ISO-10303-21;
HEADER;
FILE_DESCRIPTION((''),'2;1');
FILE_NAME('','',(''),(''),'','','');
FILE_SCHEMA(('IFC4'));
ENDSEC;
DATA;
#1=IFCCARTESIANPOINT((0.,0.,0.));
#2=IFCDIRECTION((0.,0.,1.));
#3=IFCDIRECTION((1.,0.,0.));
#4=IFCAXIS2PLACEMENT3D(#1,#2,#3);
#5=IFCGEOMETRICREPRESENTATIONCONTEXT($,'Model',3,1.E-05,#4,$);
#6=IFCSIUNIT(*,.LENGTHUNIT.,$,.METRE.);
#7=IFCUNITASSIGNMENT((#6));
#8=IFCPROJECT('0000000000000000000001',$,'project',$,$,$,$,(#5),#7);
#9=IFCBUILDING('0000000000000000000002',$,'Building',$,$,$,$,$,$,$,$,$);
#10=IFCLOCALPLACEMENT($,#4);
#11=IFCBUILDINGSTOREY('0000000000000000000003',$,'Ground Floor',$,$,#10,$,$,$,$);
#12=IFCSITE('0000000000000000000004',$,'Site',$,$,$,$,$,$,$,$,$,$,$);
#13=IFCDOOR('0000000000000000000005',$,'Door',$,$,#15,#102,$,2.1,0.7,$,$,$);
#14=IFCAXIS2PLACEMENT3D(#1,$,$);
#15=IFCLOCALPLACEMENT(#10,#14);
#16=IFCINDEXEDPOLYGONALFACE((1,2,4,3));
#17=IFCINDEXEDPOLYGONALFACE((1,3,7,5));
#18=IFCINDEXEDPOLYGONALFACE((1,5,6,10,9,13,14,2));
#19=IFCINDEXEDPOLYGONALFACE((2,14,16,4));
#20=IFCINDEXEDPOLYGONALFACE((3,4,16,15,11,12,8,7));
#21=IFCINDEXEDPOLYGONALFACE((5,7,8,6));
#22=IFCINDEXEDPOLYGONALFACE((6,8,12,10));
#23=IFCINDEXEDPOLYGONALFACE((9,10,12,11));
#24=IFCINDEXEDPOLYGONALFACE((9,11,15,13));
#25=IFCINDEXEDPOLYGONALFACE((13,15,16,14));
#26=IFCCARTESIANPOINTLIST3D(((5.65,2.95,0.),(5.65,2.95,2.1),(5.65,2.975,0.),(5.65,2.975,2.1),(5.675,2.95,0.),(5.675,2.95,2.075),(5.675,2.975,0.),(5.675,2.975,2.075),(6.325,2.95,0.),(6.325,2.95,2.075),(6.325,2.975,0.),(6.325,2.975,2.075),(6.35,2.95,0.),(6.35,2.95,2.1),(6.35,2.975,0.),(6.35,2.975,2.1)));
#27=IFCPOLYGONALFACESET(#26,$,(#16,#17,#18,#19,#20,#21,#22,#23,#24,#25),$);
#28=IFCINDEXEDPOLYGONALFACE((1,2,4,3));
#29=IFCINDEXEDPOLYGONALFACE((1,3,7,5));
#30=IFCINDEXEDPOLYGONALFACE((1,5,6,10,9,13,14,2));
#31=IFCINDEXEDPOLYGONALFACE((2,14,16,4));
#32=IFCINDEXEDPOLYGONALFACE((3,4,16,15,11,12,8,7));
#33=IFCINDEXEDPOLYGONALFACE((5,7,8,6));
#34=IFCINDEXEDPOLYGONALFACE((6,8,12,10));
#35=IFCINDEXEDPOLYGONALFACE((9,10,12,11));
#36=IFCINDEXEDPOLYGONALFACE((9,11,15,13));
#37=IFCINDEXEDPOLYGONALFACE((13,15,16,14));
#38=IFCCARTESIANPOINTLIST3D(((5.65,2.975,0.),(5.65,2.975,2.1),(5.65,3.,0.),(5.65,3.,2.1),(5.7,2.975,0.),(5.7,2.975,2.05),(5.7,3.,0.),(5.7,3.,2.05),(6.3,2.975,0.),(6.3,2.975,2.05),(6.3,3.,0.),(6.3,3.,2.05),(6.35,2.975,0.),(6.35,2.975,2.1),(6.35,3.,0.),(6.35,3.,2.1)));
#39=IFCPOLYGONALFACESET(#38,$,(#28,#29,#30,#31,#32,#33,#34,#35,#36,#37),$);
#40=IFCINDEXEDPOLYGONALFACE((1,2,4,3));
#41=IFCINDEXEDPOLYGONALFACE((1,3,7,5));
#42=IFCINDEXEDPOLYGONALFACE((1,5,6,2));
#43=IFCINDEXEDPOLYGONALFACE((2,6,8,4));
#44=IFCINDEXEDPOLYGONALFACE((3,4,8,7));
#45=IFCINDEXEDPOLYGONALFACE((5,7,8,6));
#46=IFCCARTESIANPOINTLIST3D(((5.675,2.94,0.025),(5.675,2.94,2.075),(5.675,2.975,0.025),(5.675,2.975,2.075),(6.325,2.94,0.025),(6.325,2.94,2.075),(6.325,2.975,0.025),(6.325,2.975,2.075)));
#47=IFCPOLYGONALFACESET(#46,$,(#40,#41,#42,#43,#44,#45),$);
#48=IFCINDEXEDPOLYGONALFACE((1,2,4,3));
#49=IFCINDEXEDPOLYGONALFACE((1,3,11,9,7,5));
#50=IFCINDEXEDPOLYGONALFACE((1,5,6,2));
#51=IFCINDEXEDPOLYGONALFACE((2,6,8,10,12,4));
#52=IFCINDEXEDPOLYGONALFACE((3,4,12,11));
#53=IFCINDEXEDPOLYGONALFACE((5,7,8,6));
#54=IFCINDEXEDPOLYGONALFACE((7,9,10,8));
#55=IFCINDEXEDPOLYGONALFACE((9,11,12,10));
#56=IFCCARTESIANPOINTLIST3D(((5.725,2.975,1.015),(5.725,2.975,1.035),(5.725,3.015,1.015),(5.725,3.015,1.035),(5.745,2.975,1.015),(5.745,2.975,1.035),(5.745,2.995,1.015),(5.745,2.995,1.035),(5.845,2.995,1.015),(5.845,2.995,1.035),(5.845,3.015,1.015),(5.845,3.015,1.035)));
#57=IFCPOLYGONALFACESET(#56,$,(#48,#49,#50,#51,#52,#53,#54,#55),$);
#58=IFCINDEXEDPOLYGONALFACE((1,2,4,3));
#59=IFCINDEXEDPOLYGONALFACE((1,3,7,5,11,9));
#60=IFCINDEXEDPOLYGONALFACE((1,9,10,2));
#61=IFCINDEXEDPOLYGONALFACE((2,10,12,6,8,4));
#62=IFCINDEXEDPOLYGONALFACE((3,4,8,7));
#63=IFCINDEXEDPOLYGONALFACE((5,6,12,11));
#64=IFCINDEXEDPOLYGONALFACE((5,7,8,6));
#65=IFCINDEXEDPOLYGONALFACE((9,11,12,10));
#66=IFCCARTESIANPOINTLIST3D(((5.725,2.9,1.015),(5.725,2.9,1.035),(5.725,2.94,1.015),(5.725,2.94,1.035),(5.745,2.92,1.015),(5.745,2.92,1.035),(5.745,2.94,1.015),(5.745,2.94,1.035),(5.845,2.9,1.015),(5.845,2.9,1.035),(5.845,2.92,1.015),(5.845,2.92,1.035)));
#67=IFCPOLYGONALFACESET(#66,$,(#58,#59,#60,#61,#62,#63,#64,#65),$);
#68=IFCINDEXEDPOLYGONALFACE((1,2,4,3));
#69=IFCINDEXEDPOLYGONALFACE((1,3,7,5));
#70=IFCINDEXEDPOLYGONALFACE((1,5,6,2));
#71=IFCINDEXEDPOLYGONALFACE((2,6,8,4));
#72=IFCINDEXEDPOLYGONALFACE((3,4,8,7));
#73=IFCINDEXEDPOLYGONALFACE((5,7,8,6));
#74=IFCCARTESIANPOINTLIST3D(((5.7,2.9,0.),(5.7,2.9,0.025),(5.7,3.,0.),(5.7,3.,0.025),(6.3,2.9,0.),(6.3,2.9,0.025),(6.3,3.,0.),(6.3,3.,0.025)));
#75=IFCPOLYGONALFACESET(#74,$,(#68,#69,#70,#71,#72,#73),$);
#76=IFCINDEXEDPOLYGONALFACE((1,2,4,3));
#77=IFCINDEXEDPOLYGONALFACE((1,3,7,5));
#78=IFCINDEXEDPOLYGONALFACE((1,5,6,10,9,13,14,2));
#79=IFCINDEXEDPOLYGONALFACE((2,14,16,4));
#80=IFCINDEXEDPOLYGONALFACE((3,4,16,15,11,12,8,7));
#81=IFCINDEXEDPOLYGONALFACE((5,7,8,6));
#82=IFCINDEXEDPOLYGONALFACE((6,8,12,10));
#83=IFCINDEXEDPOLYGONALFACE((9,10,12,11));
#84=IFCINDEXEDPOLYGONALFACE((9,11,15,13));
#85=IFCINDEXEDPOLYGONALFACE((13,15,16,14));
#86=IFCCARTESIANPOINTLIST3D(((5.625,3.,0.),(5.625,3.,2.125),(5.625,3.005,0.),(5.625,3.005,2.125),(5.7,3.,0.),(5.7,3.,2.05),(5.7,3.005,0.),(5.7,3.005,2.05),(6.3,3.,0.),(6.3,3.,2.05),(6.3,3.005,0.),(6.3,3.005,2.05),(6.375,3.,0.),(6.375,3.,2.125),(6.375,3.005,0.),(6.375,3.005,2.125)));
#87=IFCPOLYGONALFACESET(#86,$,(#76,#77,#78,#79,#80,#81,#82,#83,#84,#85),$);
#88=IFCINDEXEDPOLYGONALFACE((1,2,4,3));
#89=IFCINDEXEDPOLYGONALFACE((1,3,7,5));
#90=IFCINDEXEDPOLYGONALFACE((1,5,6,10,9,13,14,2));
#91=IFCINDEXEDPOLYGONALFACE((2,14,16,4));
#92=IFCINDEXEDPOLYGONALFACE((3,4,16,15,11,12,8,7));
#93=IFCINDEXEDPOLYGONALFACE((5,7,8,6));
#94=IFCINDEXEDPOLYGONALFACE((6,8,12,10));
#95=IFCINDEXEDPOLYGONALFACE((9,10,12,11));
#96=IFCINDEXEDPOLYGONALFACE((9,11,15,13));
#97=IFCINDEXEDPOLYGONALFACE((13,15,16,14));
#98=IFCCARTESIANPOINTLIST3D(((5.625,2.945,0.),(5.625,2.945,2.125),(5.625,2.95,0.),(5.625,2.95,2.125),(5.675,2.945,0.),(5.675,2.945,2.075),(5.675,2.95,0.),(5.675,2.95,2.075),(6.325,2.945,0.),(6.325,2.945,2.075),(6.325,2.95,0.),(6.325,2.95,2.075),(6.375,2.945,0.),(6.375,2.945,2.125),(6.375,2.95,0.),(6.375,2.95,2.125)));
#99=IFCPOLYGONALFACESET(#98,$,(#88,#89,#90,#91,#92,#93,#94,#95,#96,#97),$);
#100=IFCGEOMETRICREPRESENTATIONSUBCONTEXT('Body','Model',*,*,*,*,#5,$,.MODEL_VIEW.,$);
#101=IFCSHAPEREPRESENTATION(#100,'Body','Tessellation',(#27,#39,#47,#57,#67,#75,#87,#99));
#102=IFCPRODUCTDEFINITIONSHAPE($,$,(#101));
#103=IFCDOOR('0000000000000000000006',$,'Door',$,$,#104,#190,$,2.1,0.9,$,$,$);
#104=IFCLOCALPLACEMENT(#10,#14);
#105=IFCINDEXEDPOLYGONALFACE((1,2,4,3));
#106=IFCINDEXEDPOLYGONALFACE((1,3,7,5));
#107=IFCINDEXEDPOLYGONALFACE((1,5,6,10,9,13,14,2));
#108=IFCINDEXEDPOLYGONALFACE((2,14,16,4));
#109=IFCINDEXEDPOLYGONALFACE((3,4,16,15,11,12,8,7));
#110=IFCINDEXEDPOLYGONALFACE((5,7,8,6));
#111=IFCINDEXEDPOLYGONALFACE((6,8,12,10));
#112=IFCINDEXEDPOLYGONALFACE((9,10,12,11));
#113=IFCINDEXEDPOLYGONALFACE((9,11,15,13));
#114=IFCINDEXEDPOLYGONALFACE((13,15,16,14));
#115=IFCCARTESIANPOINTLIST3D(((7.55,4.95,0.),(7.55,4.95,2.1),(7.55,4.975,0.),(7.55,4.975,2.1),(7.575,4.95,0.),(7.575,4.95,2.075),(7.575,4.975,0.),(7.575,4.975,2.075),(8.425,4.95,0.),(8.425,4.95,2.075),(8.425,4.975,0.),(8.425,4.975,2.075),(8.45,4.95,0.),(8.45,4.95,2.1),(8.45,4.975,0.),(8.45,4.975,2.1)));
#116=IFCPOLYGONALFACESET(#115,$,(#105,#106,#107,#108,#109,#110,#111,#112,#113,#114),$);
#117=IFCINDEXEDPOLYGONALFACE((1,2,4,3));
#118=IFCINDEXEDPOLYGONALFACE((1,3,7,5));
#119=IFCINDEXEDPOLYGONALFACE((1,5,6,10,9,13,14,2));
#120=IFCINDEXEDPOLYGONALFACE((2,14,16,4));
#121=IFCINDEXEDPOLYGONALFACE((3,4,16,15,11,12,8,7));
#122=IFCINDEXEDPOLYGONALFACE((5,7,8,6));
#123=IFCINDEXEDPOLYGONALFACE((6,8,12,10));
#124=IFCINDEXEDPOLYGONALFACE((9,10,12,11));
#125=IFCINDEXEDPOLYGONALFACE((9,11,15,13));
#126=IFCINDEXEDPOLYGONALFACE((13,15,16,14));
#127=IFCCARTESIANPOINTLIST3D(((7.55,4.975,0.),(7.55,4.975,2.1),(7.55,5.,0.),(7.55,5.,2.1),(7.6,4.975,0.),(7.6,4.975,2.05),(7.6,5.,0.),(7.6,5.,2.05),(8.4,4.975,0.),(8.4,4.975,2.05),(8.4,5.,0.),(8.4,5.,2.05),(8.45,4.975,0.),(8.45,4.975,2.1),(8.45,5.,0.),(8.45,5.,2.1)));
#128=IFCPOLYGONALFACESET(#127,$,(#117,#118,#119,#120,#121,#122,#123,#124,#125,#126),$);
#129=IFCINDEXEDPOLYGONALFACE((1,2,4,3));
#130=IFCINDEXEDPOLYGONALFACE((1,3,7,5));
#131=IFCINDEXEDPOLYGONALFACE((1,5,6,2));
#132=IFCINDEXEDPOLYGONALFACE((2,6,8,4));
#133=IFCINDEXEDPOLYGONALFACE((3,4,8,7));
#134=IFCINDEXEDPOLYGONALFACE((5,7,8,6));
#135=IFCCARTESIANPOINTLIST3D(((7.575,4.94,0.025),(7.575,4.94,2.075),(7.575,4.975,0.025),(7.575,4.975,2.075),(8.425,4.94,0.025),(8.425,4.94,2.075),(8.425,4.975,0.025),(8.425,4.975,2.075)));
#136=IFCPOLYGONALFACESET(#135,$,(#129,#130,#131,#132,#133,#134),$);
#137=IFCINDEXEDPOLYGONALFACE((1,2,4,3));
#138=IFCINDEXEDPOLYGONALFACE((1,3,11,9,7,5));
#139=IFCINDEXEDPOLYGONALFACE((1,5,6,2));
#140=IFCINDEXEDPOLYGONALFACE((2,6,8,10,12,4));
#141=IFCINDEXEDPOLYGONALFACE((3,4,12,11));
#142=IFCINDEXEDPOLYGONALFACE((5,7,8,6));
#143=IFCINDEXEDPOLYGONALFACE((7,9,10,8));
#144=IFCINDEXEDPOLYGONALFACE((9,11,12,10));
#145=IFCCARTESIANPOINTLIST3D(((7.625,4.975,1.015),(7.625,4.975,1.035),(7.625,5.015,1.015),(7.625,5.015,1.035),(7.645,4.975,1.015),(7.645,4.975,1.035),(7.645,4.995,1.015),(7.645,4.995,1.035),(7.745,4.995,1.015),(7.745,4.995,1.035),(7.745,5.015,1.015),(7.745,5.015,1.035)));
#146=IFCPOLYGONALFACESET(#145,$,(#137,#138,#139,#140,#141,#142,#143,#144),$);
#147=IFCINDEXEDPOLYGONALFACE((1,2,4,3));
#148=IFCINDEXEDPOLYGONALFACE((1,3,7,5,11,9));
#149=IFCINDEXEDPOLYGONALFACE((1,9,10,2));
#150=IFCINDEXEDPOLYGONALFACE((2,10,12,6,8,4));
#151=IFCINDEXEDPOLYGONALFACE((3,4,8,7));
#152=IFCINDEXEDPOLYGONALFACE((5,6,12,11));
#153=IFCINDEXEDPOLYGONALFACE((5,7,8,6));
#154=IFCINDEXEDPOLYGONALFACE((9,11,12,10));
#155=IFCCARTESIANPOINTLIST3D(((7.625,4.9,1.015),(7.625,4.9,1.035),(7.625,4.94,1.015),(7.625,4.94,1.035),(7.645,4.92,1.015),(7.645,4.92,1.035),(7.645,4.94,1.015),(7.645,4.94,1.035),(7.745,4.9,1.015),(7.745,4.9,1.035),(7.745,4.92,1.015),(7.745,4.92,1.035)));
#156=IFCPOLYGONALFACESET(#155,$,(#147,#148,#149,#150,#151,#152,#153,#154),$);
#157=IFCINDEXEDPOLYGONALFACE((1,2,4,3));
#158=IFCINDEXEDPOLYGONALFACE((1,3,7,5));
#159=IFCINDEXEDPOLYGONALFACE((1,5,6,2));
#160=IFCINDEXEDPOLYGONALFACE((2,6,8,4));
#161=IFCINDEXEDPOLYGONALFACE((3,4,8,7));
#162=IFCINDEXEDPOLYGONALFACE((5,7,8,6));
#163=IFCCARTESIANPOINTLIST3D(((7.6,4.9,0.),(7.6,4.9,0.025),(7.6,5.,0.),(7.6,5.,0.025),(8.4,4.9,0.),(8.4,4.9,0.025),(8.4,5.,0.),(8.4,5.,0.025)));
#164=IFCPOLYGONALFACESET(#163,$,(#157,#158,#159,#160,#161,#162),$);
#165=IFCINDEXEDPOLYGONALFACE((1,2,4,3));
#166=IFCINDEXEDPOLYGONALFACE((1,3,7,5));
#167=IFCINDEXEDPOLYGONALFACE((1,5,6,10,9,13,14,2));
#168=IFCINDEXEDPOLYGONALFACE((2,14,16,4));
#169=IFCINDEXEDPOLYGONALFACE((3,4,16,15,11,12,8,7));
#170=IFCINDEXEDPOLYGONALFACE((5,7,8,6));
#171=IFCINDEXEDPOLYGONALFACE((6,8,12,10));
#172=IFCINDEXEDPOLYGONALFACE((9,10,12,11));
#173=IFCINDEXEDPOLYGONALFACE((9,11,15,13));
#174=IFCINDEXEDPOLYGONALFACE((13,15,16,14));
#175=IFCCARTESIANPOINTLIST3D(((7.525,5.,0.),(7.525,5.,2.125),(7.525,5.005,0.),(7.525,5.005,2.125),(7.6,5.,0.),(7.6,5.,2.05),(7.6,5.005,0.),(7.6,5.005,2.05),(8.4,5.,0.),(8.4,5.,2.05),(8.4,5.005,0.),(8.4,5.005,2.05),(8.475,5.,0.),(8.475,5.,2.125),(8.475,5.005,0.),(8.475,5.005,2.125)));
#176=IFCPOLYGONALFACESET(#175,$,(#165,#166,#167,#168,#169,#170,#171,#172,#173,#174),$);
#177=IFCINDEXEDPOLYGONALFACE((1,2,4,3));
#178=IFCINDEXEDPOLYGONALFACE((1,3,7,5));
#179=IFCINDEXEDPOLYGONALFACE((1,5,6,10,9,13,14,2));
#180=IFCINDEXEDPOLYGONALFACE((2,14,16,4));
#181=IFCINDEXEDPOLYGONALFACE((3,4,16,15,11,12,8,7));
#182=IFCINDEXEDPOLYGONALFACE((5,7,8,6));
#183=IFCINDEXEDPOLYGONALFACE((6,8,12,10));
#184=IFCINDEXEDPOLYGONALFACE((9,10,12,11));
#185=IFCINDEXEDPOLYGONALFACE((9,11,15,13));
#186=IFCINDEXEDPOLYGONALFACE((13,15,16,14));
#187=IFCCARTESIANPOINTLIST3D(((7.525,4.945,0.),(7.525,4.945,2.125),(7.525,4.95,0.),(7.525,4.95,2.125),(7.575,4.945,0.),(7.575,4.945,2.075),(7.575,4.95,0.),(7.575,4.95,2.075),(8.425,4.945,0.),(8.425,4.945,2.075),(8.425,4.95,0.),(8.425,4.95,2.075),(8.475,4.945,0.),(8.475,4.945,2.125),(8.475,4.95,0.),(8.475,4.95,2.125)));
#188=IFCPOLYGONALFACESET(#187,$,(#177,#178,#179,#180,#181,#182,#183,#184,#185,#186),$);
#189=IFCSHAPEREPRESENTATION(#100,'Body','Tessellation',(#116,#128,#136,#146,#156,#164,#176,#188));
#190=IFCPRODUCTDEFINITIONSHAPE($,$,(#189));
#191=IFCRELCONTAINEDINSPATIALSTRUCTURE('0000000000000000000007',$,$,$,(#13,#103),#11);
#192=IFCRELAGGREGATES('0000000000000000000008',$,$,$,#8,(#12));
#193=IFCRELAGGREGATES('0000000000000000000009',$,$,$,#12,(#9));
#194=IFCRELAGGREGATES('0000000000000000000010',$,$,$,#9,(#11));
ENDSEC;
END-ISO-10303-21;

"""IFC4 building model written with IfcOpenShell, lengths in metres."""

from ifc_helpers import new_model, si_unit, frame, origin_with_axes, place, context, subcontext, project, spatial, line, indexed_curve, outline, extrude, element, save


model = new_model("IFC4")

# Units and contexts
model_context = context("Model", 3, precision=1e-05, world=origin_with_axes())
body_context = subcontext(model_context, "Body", "Model", "MODEL_VIEW")
ifc_project = project(units=[si_unit("LENGTHUNIT", "METRE")], contexts=[model_context])

# Site, building, storey
site = spatial("IfcSite", under=ifc_project, Name="Site")
building = spatial("IfcBuilding", under=site, Name="Building")
storey_placement = place(None, origin_with_axes())
storey = spatial("IfcBuildingStorey", under=building, at=storey_placement, Name="Ground Floor")

# Doors
door_1_placement = place(storey_placement, frame((6.35, 3.0, 0.0), z_axis=(0.0, 0.0, 1.0), x_axis=(-1.0, 0.0, 0.0)))
element("IfcDoor", 1, at=door_1_placement, inside=storey, Name="Door", OverallHeight=2.1, OverallWidth=0.7, context=body_context, shape_type="SweptSolid", body=[
    extrude(outline(indexed_curve([(0.0, 0.0), (0.0, 2.1), (0.7, 2.1), (0.7, 0.0), (0.675, 0.0), (0.675, 2.075), (0.025, 2.075), (0.025, 0.0)], segments=[line(1, 2, 3, 4, 5, 6, 7, 8, 1)])), frame((0.0, 0.025, 0.0), z_axis=(0.0, -1.0, 0.0), x_axis=(1.0, 0.0, 0.0)), (0.0, 0.0, -1.0), 0.025),
    extrude(outline(indexed_curve([(0.0, 0.0), (0.0, 2.1), (0.7, 2.1), (0.7, 0.0), (0.65, 0.0), (0.65, 2.05), (0.05, 2.05), (0.05, 0.0)], segments=[line(1, 2, 3, 4, 5, 6, 7, 8, 1)])), frame((0.0, 0.0, 0.0), z_axis=(0.0, -1.0, 0.0), x_axis=(1.0, 0.0, 0.0)), (0.0, 0.0, -1.0), 0.025),
    extrude(outline(indexed_curve([(0.0, 0.0), (0.65, 0.0), (0.65, 0.035), (0.0, 0.035)], segments=[line(1, 2, 3, 4, 1)])), frame((0.025, 0.025, 0.025), z_axis=(0.0, 0.0, 1.0), x_axis=(1.0, 0.0, 0.0)), (0.0, 0.0, 1.0), 2.05),
    extrude(outline(indexed_curve([(0.0, 0.0), (0.0, -0.04), (-0.12, -0.04), (-0.12, -0.02), (-0.02, -0.02), (-0.02, 0.0)], segments=[line(1, 2, 3, 4, 5, 6, 1)])), frame((0.625, 0.025, 1.015), z_axis=(0.0, 0.0, 1.0), x_axis=(1.0, 0.0, 0.0)), (0.0, 0.0, 1.0), 0.02),
    extrude(outline(indexed_curve([(0.0, 0.0), (0.0, 0.04), (-0.12, 0.04), (-0.12, 0.02), (-0.02, 0.02), (-0.02, 0.0)], segments=[line(1, 2, 3, 4, 5, 6, 1)])), frame((0.625, 0.06, 1.015), z_axis=(0.0, 0.0, 1.0), x_axis=(1.0, 0.0, 0.0)), (0.0, 0.0, 1.0), 0.02),
    extrude(outline(indexed_curve([(0.0, 0.0), (0.6, 0.0), (0.6, 0.1), (0.0, 0.1)], segments=[line(1, 2, 3, 4, 1)])), frame((0.05, 0.0, 0.0), z_axis=(0.0, 0.0, 1.0), x_axis=(1.0, 0.0, 0.0)), (0.0, 0.0, 1.0), 0.025),
    extrude(outline(indexed_curve([(0.0, 0.0), (0.0, 2.125), (0.75, 2.125), (0.75, 0.0), (0.675, 0.0), (0.675, 2.05), (0.075, 2.05), (0.075, 0.0)], segments=[line(1, 2, 3, 4, 5, 6, 7, 8, 1)])), frame((-0.025, -0.005, 0.0), z_axis=(0.0, -1.0, 0.0), x_axis=(1.0, 0.0, 0.0)), (0.0, 0.0, -1.0), 0.005),
    extrude(outline(indexed_curve([(0.0, 0.0), (0.0, 2.125), (0.75, 2.125), (0.75, 0.0), (0.7, 0.0), (0.7, 2.075), (0.05, 2.075), (0.05, 0.0)], segments=[line(1, 2, 3, 4, 5, 6, 7, 8, 1)])), frame((-0.025, 0.05, 0.0), z_axis=(0.0, -1.0, 0.0), x_axis=(1.0, 0.0, 0.0)), (0.0, 0.0, -1.0), 0.005),
])
door_2_placement = place(storey_placement, frame((8.45, 5.0, 0.0), z_axis=(0.0, 0.0, 1.0), x_axis=(-1.0, 0.0, 0.0)))
element("IfcDoor", 2, at=door_2_placement, inside=storey, Name="Door", OverallHeight=2.1, OverallWidth=0.9, context=body_context, shape_type="SweptSolid", body=[
    extrude(outline(indexed_curve([(0.0, 0.0), (0.0, 2.1), (0.9, 2.1), (0.9, 0.0), (0.875, 0.0), (0.875, 2.075), (0.025, 2.075), (0.025, 0.0)], segments=[line(1, 2, 3, 4, 5, 6, 7, 8, 1)])), frame((0.0, 0.025, 0.0), z_axis=(0.0, -1.0, 0.0), x_axis=(1.0, 0.0, 0.0)), (0.0, 0.0, -1.0), 0.025),
    extrude(outline(indexed_curve([(0.0, 0.0), (0.0, 2.1), (0.9, 2.1), (0.9, 0.0), (0.85, 0.0), (0.85, 2.05), (0.05, 2.05), (0.05, 0.0)], segments=[line(1, 2, 3, 4, 5, 6, 7, 8, 1)])), frame((0.0, 0.0, 0.0), z_axis=(0.0, -1.0, 0.0), x_axis=(1.0, 0.0, 0.0)), (0.0, 0.0, -1.0), 0.025),
    extrude(outline(indexed_curve([(0.0, 0.0), (0.85, 0.0), (0.85, 0.035), (0.0, 0.035)], segments=[line(1, 2, 3, 4, 1)])), frame((0.025, 0.025, 0.025), z_axis=(0.0, 0.0, 1.0), x_axis=(1.0, 0.0, 0.0)), (0.0, 0.0, 1.0), 2.05),
    extrude(outline(indexed_curve([(0.0, 0.0), (0.0, -0.04), (-0.12, -0.04), (-0.12, -0.02), (-0.02, -0.02), (-0.02, 0.0)], segments=[line(1, 2, 3, 4, 5, 6, 1)])), frame((0.825, 0.025, 1.015), z_axis=(0.0, 0.0, 1.0), x_axis=(1.0, 0.0, 0.0)), (0.0, 0.0, 1.0), 0.02),
    extrude(outline(indexed_curve([(0.0, 0.0), (0.0, 0.04), (-0.12, 0.04), (-0.12, 0.02), (-0.02, 0.02), (-0.02, 0.0)], segments=[line(1, 2, 3, 4, 5, 6, 1)])), frame((0.825, 0.06, 1.015), z_axis=(0.0, 0.0, 1.0), x_axis=(1.0, 0.0, 0.0)), (0.0, 0.0, 1.0), 0.02),
    extrude(outline(indexed_curve([(0.0, 0.0), (0.8, 0.0), (0.8, 0.1), (0.0, 0.1)], segments=[line(1, 2, 3, 4, 1)])), frame((0.05, 0.0, 0.0), z_axis=(0.0, 0.0, 1.0), x_axis=(1.0, 0.0, 0.0)), (0.0, 0.0, 1.0), 0.025),
    extrude(outline(indexed_curve([(0.0, 0.0), (0.0, 2.125), (0.95, 2.125), (0.95, 0.0), (0.875, 0.0), (0.875, 2.05), (0.075, 2.05), (0.075, 0.0)], segments=[line(1, 2, 3, 4, 5, 6, 7, 8, 1)])), frame((-0.025, -0.005, 0.0), z_axis=(0.0, -1.0, 0.0), x_axis=(1.0, 0.0, 0.0)), (0.0, 0.0, -1.0), 0.005),
    extrude(outline(indexed_curve([(0.0, 0.0), (0.0, 2.125), (0.95, 2.125), (0.95, 0.0), (0.9, 0.0), (0.9, 2.075), (0.05, 2.075), (0.05, 0.0)], segments=[line(1, 2, 3, 4, 5, 6, 7, 8, 1)])), frame((-0.025, 0.05, 0.0), z_axis=(0.0, -1.0, 0.0), x_axis=(1.0, 0.0, 0.0)), (0.0, 0.0, -1.0), 0.005),
])

save(model, "model.ifc")
